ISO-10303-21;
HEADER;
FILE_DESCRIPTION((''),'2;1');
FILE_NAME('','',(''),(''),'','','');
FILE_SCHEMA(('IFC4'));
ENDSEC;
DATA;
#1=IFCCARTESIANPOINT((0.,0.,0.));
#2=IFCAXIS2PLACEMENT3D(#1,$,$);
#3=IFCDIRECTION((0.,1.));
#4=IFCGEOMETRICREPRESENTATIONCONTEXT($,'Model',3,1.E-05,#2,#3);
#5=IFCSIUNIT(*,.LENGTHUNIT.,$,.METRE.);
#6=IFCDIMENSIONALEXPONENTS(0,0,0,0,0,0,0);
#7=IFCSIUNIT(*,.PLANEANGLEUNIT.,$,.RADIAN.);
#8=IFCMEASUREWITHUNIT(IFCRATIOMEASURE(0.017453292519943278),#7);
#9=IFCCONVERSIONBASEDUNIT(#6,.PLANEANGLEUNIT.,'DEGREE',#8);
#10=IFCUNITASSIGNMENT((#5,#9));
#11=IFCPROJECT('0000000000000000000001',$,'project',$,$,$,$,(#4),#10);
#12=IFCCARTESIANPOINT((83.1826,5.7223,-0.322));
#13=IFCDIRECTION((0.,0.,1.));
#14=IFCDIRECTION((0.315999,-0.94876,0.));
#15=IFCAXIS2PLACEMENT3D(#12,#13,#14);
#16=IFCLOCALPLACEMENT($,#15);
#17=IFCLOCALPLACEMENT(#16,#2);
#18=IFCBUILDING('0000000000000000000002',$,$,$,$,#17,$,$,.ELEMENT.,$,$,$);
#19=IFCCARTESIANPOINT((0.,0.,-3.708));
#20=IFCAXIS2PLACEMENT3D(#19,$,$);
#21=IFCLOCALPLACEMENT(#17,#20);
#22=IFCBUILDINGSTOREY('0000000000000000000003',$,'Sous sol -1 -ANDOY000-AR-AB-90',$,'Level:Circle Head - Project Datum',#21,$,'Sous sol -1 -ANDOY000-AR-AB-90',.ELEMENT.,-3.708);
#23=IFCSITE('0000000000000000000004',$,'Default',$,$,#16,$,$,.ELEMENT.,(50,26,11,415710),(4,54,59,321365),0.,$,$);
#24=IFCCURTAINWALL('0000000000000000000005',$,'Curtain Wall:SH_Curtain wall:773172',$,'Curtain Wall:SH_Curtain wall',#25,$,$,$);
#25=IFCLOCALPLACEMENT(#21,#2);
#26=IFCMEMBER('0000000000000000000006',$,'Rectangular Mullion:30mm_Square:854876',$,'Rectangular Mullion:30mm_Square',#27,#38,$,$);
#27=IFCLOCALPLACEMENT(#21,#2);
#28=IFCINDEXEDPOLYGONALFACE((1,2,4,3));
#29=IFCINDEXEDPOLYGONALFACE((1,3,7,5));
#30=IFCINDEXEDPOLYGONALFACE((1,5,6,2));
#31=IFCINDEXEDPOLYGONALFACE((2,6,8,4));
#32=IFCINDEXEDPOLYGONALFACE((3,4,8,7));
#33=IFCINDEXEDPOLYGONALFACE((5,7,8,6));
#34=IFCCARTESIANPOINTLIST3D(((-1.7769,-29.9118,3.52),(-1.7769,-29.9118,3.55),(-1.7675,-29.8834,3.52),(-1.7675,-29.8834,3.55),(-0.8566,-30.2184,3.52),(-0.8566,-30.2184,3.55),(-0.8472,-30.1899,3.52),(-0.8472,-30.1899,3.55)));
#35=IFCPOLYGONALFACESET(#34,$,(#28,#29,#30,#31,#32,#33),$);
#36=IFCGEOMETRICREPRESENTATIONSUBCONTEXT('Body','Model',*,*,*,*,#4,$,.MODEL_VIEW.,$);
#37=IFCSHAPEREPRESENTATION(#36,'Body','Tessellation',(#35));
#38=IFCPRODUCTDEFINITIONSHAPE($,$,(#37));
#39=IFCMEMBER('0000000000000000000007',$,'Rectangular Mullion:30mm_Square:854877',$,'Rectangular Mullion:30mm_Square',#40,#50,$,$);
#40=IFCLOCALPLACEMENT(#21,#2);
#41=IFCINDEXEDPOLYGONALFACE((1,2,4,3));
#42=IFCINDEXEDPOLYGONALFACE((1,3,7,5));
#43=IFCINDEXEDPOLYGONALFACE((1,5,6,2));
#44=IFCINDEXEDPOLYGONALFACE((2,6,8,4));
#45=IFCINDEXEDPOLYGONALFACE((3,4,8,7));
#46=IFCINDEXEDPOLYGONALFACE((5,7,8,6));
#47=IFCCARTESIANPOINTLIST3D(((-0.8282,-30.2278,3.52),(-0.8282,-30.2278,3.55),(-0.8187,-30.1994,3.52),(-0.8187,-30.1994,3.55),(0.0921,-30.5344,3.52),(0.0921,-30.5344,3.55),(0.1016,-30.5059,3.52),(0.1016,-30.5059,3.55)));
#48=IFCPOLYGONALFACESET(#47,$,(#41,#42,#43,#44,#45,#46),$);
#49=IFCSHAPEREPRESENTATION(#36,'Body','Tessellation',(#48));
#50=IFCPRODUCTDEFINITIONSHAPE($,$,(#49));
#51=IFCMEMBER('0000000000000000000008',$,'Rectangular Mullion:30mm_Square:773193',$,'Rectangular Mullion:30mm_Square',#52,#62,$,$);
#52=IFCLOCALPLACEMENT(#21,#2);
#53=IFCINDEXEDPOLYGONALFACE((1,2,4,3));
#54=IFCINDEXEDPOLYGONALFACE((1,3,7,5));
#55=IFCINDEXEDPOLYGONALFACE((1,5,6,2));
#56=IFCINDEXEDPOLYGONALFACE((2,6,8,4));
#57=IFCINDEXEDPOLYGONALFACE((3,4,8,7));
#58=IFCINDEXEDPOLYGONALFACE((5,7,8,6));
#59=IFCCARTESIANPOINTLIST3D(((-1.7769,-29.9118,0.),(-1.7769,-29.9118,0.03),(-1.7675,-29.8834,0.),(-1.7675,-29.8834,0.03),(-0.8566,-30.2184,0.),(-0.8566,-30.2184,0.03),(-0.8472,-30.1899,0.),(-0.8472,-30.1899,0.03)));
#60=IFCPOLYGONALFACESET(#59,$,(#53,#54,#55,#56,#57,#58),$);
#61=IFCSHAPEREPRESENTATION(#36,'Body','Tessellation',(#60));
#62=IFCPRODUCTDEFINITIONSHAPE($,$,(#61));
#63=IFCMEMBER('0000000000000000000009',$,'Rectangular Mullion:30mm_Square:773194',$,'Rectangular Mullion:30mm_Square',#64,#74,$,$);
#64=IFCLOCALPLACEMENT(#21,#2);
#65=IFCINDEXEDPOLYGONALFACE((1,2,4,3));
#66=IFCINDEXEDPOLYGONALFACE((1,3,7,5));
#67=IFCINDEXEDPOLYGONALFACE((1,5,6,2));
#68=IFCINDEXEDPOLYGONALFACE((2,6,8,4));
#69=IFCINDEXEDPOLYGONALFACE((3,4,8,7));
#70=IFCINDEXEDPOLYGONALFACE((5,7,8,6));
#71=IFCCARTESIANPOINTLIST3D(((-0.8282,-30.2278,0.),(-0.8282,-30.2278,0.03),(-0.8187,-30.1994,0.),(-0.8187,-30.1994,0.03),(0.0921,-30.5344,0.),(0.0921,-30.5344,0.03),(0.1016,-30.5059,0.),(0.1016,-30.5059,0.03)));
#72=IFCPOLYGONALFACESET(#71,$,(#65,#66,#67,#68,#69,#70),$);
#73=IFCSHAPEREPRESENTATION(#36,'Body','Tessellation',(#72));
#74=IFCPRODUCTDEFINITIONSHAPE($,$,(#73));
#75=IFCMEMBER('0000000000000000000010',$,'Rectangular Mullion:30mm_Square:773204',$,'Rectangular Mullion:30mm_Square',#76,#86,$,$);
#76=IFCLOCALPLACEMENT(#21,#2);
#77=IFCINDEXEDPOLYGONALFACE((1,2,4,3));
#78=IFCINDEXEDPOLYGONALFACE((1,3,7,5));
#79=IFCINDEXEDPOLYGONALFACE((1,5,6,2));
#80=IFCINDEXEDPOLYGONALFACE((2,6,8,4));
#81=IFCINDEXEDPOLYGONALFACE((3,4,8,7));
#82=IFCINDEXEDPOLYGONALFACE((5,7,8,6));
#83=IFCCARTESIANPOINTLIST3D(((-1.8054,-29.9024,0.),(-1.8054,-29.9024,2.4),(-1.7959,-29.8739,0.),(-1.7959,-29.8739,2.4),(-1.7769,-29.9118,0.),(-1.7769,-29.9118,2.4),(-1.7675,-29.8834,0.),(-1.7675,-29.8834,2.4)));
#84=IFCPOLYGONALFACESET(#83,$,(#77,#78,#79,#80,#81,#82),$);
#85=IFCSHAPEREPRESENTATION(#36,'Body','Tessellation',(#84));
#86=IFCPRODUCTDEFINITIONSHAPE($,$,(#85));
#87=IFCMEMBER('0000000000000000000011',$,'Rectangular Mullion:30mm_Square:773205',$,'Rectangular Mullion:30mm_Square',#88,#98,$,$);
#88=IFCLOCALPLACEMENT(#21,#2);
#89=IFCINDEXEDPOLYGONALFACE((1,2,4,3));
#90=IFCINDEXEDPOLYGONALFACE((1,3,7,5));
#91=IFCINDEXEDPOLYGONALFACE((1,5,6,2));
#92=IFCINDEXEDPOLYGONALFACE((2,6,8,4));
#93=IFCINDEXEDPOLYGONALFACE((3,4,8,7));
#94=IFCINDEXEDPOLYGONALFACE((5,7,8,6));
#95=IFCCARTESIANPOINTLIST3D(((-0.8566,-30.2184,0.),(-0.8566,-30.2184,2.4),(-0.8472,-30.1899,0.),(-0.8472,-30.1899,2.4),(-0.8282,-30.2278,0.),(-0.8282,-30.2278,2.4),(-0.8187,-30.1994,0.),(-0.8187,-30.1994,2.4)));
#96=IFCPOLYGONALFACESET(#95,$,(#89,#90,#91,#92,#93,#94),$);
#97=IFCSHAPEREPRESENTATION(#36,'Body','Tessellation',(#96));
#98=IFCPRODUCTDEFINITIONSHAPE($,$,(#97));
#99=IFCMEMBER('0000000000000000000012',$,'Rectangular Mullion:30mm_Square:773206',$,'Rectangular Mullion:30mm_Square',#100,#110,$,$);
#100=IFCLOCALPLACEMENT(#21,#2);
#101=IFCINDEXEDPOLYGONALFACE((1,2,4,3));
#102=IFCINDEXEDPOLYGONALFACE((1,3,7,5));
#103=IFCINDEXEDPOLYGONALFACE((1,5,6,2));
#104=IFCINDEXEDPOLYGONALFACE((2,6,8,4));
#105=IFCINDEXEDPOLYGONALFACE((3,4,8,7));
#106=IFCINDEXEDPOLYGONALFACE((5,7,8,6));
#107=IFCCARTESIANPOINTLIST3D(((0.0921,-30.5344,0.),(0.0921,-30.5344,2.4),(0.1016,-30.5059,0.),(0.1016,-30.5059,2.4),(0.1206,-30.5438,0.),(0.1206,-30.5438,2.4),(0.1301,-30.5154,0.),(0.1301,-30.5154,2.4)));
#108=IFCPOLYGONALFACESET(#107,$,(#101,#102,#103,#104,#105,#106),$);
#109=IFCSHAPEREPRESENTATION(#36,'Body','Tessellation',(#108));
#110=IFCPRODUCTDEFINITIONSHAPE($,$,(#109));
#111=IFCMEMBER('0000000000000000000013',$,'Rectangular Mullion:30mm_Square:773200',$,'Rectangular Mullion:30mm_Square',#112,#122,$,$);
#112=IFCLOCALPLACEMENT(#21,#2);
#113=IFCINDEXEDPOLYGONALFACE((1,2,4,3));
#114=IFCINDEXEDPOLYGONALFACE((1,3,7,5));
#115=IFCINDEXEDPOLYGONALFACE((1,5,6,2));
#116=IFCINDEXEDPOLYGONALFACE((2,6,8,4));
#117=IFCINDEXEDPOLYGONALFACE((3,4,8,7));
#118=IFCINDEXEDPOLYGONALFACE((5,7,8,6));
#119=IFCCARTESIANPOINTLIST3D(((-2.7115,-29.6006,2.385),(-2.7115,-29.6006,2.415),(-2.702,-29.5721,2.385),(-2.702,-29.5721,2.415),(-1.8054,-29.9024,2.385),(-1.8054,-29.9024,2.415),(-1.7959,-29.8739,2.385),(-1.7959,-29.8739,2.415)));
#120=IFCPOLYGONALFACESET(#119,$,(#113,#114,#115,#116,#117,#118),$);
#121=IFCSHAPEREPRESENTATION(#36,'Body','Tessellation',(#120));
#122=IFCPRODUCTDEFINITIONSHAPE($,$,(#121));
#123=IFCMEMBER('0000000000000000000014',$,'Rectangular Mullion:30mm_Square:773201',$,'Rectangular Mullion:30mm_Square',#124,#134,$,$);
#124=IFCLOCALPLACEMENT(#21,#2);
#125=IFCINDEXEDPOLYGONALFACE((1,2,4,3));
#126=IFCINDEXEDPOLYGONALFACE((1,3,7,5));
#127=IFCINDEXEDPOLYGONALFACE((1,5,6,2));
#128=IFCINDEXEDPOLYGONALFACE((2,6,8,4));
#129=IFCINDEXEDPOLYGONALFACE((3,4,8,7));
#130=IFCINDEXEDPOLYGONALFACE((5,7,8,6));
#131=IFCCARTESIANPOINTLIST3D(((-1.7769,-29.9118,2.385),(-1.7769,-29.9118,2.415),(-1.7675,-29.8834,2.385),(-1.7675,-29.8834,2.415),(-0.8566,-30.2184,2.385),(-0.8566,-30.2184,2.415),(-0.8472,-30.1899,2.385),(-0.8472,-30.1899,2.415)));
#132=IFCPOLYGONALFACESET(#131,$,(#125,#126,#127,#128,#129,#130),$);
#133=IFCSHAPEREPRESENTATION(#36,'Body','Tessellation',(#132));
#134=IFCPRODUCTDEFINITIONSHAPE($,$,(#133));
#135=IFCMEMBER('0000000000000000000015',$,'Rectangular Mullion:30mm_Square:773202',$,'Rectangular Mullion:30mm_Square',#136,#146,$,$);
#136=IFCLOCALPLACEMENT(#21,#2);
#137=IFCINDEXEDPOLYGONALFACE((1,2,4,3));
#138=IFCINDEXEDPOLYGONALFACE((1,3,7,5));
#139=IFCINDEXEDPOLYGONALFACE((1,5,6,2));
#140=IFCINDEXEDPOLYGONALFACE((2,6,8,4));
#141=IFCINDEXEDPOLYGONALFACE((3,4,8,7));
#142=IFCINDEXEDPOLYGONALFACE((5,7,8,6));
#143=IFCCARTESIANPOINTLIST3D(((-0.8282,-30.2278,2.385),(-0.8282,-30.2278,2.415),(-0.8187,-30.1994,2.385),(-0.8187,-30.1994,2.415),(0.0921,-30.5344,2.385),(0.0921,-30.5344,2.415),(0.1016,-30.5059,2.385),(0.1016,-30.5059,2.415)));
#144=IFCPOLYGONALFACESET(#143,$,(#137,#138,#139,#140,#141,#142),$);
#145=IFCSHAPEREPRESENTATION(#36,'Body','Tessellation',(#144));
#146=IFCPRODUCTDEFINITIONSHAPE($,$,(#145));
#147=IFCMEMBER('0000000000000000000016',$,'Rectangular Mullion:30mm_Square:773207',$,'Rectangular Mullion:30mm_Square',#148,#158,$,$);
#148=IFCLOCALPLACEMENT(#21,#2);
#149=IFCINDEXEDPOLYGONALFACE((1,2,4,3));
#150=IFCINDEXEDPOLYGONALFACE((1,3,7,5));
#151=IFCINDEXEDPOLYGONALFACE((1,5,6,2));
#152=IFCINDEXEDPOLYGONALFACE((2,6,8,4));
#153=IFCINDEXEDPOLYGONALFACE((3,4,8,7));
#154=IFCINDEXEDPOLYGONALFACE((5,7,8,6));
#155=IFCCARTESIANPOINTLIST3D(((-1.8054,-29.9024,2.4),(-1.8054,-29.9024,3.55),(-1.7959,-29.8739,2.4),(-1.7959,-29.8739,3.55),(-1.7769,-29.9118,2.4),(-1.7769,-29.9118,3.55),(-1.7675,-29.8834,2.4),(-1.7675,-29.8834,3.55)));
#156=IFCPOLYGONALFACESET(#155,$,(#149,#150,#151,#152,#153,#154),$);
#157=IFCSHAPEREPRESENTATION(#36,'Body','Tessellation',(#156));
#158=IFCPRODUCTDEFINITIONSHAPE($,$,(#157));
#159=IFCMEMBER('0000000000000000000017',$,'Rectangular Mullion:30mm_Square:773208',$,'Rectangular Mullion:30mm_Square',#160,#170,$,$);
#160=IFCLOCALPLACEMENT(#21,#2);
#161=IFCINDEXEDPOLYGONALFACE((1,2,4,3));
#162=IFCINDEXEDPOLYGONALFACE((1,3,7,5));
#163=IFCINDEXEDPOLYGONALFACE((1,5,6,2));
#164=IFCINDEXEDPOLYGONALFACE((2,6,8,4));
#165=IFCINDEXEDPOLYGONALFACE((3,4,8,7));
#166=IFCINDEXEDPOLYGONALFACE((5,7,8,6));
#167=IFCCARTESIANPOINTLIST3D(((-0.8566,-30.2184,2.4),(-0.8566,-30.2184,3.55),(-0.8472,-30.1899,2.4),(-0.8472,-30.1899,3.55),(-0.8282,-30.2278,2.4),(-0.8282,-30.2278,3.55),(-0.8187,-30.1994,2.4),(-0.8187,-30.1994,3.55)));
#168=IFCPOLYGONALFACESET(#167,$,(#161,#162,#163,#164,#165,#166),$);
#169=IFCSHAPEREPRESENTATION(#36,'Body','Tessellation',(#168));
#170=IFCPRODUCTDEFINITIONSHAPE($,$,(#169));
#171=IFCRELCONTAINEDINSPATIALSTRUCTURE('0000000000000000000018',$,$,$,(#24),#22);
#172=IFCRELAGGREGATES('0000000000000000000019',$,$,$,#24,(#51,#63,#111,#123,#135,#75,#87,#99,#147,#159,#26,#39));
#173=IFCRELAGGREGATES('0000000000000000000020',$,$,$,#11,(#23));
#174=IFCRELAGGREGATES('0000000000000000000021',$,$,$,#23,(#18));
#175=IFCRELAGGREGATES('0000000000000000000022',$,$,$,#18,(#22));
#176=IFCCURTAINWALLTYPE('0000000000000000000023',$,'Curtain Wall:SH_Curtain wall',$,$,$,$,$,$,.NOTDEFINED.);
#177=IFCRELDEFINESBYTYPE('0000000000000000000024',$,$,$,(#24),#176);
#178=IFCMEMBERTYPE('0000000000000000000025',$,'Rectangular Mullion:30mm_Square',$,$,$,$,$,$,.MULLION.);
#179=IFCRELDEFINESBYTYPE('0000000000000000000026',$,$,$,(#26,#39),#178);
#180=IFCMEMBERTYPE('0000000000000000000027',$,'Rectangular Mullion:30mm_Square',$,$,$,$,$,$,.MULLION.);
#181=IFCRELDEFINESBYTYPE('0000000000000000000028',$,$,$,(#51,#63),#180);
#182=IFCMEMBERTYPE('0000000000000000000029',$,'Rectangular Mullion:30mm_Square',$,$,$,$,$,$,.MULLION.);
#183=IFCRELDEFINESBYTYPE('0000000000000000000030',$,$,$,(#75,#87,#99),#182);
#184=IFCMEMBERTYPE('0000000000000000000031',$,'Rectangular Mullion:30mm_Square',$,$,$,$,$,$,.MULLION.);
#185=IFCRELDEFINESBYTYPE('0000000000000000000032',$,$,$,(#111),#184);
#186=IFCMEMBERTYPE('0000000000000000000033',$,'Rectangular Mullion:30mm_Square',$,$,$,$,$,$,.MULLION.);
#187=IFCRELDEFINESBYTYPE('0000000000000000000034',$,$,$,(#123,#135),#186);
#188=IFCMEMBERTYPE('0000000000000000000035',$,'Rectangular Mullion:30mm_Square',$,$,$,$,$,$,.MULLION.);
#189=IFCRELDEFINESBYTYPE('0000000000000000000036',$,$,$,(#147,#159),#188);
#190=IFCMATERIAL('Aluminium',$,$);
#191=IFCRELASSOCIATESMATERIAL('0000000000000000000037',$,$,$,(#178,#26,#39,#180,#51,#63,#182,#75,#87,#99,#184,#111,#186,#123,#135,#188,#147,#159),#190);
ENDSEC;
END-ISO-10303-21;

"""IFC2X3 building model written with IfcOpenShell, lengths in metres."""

from ifc_helpers import new_model, entity, si_unit, converted_unit, direction, frame, origin, origin_2d_with_axis, place, context, subcontext, project, spatial, rectangle, extrude, source, transform, mapped, material, type_object, type_shapes, element, aggregate, save


model = new_model("IFC2X3")

# Units and contexts
model_context = context("Model", 3, precision=1e-05, world=origin(), true_north=direction((0.0, 1.0)))
body_context = subcontext(model_context, "Body", "Model", "MODEL_VIEW")
ifc_project = project(units=[si_unit("LENGTHUNIT", "METRE"), converted_unit("PLANEANGLEUNIT", "DEGREE", entity("IfcRatioMeasure", 0.017453292519943278), si_unit("PLANEANGLEUNIT", "RADIAN"), dimensions=[0, 0, 0, 0, 0, 0, 0])], contexts=[model_context])

# Site, building, storey
site_placement = place(None, frame((83.1826, 5.7223, -0.322), z_axis=(0.0, 0.0, 1.0), x_axis=(0.315999, -0.94876, 0.0)))
site = spatial("IfcSite", under=ifc_project, at=site_placement, Name="Default", CompositionType="ELEMENT", RefLatitude=(50, 26, 11, 415710), RefLongitude=(4, 54, 59, 321365), RefElevation=0.0)
building_placement = place(site_placement, origin())
building = spatial("IfcBuilding", under=site, at=building_placement, CompositionType="ELEMENT")
storey_placement = place(building_placement, frame((0.0, 0.0, -3.708)))
storey = spatial("IfcBuildingStorey", under=building, at=storey_placement, Name="Sous sol -1 -ANDOY000-AR-AB-90", ObjectType="Level:Circle Head - Project Datum", LongName="Sous sol -1 -ANDOY000-AR-AB-90", CompositionType="ELEMENT", Elevation=-3.708)

# Curtain wall, members
curtain_wall_type = type_object("IfcCurtainWallType", Name="Curtain Wall:SH_Curtain wall", PredefinedType="NOTDEFINED")
curtain_wall_placement = place(storey_placement, frame((0.0, 0.0, 3.708)))
curtain_wall = element("IfcCurtainWall", 1, at=curtain_wall_placement, inside=storey, type_object=curtain_wall_type, Name="Curtain Wall:SH_Curtain wall:773172", ObjectType="Curtain Wall:SH_Curtain wall")
ifc_material_1 = material(Name="Aluminium")
member_type_1 = type_object("IfcMemberType", Name="Rectangular Mullion:30mm_Square", PredefinedType="MULLION", material=ifc_material_1)
shared_shape_1 = source(origin(), body_context, "Body", "SweptSolid", [
    extrude(rectangle(XDim=0.03, YDim=0.03, at=origin_2d_with_axis()), frame((-0.015, 0.0, -0.97), z_axis=(0.0, 0.0, 1.0), x_axis=(0.0, -1.0, 0.0)), (0.0, 0.0, 1.0), 0.97),
])
type_shapes(member_type_1, [shared_shape_1])
member_1_placement = place(curtain_wall_placement, frame((-0.8519, -30.2041, -0.158), z_axis=(0.948759, -0.316, 0.0), x_axis=(0.0, 0.0, 1.0)))
member_1 = element("IfcMember", 2, at=member_1_placement, type_object=member_type_1, material=ifc_material_1, Name="Rectangular Mullion:30mm_Square:854876", ObjectType="Rectangular Mullion:30mm_Square", context=body_context, shape_type="MappedRepresentation", body=[
    mapped(shared_shape_1, transform((0.0, 0.0, 0.0), scale=1.0)),
])
member_2_placement = place(curtain_wall_placement, frame((0.0969, -30.5201, -0.158), z_axis=(0.948759, -0.316, 0.0), x_axis=(0.0, 0.0, 1.0)))
member_2 = element("IfcMember", 3, at=member_2_placement, type_object=member_type_1, material=ifc_material_1, Name="Rectangular Mullion:30mm_Square:854877", ObjectType="Rectangular Mullion:30mm_Square", context=body_context, shape_type="MappedRepresentation", body=[
    mapped(shared_shape_1, transform((0.0, 0.0, 0.0), scale=1.0)),
])
member_type_2 = type_object("IfcMemberType", Name="Rectangular Mullion:30mm_Square", PredefinedType="MULLION", material=ifc_material_1)
shared_shape_2 = source(origin(), body_context, "Body", "SweptSolid", [
    extrude(rectangle(XDim=0.03, YDim=0.03, at=origin_2d_with_axis()), frame((-0.015, 0.0, -0.97), z_axis=(0.0, 0.0, 1.0), x_axis=(0.0, -1.0, 0.0)), (0.0, 0.0, 1.0), 0.97),
])
type_shapes(member_type_2, [shared_shape_2])
member_3_placement = place(curtain_wall_placement, frame((-1.7722, -29.8976, -3.708), z_axis=(-0.948759, 0.316, 0.0), x_axis=(0.0, 0.0, -1.0)))
member_3 = element("IfcMember", 4, at=member_3_placement, type_object=member_type_2, material=ifc_material_1, Name="Rectangular Mullion:30mm_Square:773193", ObjectType="Rectangular Mullion:30mm_Square", context=body_context, shape_type="MappedRepresentation", body=[
    mapped(shared_shape_2, transform((0.0, 0.0, 0.0), scale=1.0)),
])
member_4_placement = place(curtain_wall_placement, frame((-0.8234, -30.2136, -3.708), z_axis=(-0.948759, 0.316, 0.0), x_axis=(0.0, 0.0, -1.0)))
member_4 = element("IfcMember", 5, at=member_4_placement, type_object=member_type_2, material=ifc_material_1, Name="Rectangular Mullion:30mm_Square:773194", ObjectType="Rectangular Mullion:30mm_Square", context=body_context, shape_type="MappedRepresentation", body=[
    mapped(shared_shape_2, transform((0.0, 0.0, 0.0), scale=1.0)),
])
member_type_3 = type_object("IfcMemberType", Name="Rectangular Mullion:30mm_Square", PredefinedType="MULLION", material=ifc_material_1)
shared_shape_3 = source(origin(), body_context, "Body", "SweptSolid", [
    extrude(rectangle(XDim=0.03, YDim=0.03, at=origin_2d_with_axis()), frame((0.0, 0.0, -2.4), z_axis=(0.0, 0.0, 1.0), x_axis=(0.0, -1.0, 0.0)), (0.0, 0.0, 1.0), 2.4),
])
type_shapes(member_type_3, [shared_shape_3])
member_5_placement = place(curtain_wall_placement, frame((-1.7864, -29.8929, -3.708), z_axis=(0.0, 0.0, -1.0), x_axis=(0.948759, -0.316, 0.0)))
member_5 = element("IfcMember", 6, at=member_5_placement, type_object=member_type_3, material=ifc_material_1, Name="Rectangular Mullion:30mm_Square:773204", ObjectType="Rectangular Mullion:30mm_Square", context=body_context, shape_type="MappedRepresentation", body=[
    mapped(shared_shape_3, transform((0.0, 0.0, 0.0), scale=1.0)),
])
member_6_placement = place(curtain_wall_placement, frame((-0.8377, -30.2089, -3.708), z_axis=(0.0, 0.0, -1.0), x_axis=(0.948759, -0.316, 0.0)))
member_6 = element("IfcMember", 7, at=member_6_placement, type_object=member_type_3, material=ifc_material_1, Name="Rectangular Mullion:30mm_Square:773205", ObjectType="Rectangular Mullion:30mm_Square", context=body_context, shape_type="MappedRepresentation", body=[
    mapped(shared_shape_3, transform((0.0, 0.0, 0.0), scale=1.0)),
])
member_7_placement = place(curtain_wall_placement, frame((0.1111, -30.5249, -3.708), z_axis=(0.0, 0.0, -1.0), x_axis=(0.948759, -0.316, 0.0)))
member_7 = element("IfcMember", 8, at=member_7_placement, type_object=member_type_3, material=ifc_material_1, Name="Rectangular Mullion:30mm_Square:773206", ObjectType="Rectangular Mullion:30mm_Square", context=body_context, shape_type="MappedRepresentation", body=[
    mapped(shared_shape_3, transform((0.0, 0.0, 0.0), scale=1.0)),
])
member_type_4 = type_object("IfcMemberType", Name="Rectangular Mullion:30mm_Square", PredefinedType="MULLION", material=ifc_material_1)
shared_shape_4 = source(origin(), body_context, "Body", "SweptSolid", [
    extrude(rectangle(XDim=0.03, YDim=0.03, at=origin_2d_with_axis()), frame((0.0, 0.0, -0.955), z_axis=(0.0, 0.0, 1.0), x_axis=(0.0, -1.0, 0.0)), (0.0, 0.0, 1.0), 0.955),
])
type_shapes(member_type_4, [shared_shape_4])
member_8_placement = place(curtain_wall_placement, frame((-1.8007, -29.8881, -1.308), z_axis=(0.948759, -0.316, 0.0), x_axis=(0.0, 0.0, 1.0)))
member_8 = element("IfcMember", 9, at=member_8_placement, type_object=member_type_4, material=ifc_material_1, Name="Rectangular Mullion:30mm_Square:773200", ObjectType="Rectangular Mullion:30mm_Square", context=body_context, shape_type="MappedRepresentation", body=[
    mapped(shared_shape_4, transform((0.0, 0.0, 0.0), scale=1.0)),
])
member_type_5 = type_object("IfcMemberType", Name="Rectangular Mullion:30mm_Square", PredefinedType="MULLION", material=ifc_material_1)
shared_shape_5 = source(origin(), body_context, "Body", "SweptSolid", [
    extrude(rectangle(XDim=0.03, YDim=0.03, at=origin_2d_with_axis()), frame((0.0, 0.0, -0.97), z_axis=(0.0, 0.0, 1.0), x_axis=(0.0, -1.0, 0.0)), (0.0, 0.0, 1.0), 0.97),
])
type_shapes(member_type_5, [shared_shape_5])
member_9_placement = place(curtain_wall_placement, frame((-0.8519, -30.2041, -1.308), z_axis=(0.948759, -0.316, 0.0), x_axis=(0.0, 0.0, 1.0)))
member_9 = element("IfcMember", 10, at=member_9_placement, type_object=member_type_5, material=ifc_material_1, Name="Rectangular Mullion:30mm_Square:773201", ObjectType="Rectangular Mullion:30mm_Square", context=body_context, shape_type="MappedRepresentation", body=[
    mapped(shared_shape_5, transform((0.0, 0.0, 0.0), scale=1.0)),
])
member_10_placement = place(curtain_wall_placement, frame((0.0969, -30.5201, -1.308), z_axis=(0.948759, -0.316, 0.0), x_axis=(0.0, 0.0, 1.0)))
member_10 = element("IfcMember", 11, at=member_10_placement, type_object=member_type_5, material=ifc_material_1, Name="Rectangular Mullion:30mm_Square:773202", ObjectType="Rectangular Mullion:30mm_Square", context=body_context, shape_type="MappedRepresentation", body=[
    mapped(shared_shape_5, transform((0.0, 0.0, 0.0), scale=1.0)),
])
member_type_6 = type_object("IfcMemberType", Name="Rectangular Mullion:30mm_Square", PredefinedType="MULLION", material=ifc_material_1)
shared_shape_6 = source(origin(), body_context, "Body", "SweptSolid", [
    extrude(rectangle(XDim=0.03, YDim=0.03, at=origin_2d_with_axis()), frame((0.0, 0.0, -1.15), z_axis=(0.0, 0.0, 1.0), x_axis=(0.0, -1.0, 0.0)), (0.0, 0.0, 1.0), 1.15),
])
type_shapes(member_type_6, [shared_shape_6])
member_11_placement = place(curtain_wall_placement, frame((-1.7864, -29.8929, -1.308), z_axis=(0.0, 0.0, -1.0), x_axis=(0.948759, -0.316, 0.0)))
member_11 = element("IfcMember", 12, at=member_11_placement, type_object=member_type_6, material=ifc_material_1, Name="Rectangular Mullion:30mm_Square:773207", ObjectType="Rectangular Mullion:30mm_Square", context=body_context, shape_type="MappedRepresentation", body=[
    mapped(shared_shape_6, transform((0.0, 0.0, 0.0), scale=1.0)),
])
member_12_placement = place(curtain_wall_placement, frame((-0.8377, -30.2089, -1.308), z_axis=(0.0, 0.0, -1.0), x_axis=(0.948759, -0.316, 0.0)))
member_12 = element("IfcMember", 13, at=member_12_placement, type_object=member_type_6, material=ifc_material_1, Name="Rectangular Mullion:30mm_Square:773208", ObjectType="Rectangular Mullion:30mm_Square", context=body_context, shape_type="MappedRepresentation", body=[
    mapped(shared_shape_6, transform((0.0, 0.0, 0.0), scale=1.0)),
])
aggregate(curtain_wall, [member_3, member_4, member_8, member_9, member_10, member_5, member_6, member_7, member_11, member_12, member_1, member_2])

save(model, "model.ifc")
